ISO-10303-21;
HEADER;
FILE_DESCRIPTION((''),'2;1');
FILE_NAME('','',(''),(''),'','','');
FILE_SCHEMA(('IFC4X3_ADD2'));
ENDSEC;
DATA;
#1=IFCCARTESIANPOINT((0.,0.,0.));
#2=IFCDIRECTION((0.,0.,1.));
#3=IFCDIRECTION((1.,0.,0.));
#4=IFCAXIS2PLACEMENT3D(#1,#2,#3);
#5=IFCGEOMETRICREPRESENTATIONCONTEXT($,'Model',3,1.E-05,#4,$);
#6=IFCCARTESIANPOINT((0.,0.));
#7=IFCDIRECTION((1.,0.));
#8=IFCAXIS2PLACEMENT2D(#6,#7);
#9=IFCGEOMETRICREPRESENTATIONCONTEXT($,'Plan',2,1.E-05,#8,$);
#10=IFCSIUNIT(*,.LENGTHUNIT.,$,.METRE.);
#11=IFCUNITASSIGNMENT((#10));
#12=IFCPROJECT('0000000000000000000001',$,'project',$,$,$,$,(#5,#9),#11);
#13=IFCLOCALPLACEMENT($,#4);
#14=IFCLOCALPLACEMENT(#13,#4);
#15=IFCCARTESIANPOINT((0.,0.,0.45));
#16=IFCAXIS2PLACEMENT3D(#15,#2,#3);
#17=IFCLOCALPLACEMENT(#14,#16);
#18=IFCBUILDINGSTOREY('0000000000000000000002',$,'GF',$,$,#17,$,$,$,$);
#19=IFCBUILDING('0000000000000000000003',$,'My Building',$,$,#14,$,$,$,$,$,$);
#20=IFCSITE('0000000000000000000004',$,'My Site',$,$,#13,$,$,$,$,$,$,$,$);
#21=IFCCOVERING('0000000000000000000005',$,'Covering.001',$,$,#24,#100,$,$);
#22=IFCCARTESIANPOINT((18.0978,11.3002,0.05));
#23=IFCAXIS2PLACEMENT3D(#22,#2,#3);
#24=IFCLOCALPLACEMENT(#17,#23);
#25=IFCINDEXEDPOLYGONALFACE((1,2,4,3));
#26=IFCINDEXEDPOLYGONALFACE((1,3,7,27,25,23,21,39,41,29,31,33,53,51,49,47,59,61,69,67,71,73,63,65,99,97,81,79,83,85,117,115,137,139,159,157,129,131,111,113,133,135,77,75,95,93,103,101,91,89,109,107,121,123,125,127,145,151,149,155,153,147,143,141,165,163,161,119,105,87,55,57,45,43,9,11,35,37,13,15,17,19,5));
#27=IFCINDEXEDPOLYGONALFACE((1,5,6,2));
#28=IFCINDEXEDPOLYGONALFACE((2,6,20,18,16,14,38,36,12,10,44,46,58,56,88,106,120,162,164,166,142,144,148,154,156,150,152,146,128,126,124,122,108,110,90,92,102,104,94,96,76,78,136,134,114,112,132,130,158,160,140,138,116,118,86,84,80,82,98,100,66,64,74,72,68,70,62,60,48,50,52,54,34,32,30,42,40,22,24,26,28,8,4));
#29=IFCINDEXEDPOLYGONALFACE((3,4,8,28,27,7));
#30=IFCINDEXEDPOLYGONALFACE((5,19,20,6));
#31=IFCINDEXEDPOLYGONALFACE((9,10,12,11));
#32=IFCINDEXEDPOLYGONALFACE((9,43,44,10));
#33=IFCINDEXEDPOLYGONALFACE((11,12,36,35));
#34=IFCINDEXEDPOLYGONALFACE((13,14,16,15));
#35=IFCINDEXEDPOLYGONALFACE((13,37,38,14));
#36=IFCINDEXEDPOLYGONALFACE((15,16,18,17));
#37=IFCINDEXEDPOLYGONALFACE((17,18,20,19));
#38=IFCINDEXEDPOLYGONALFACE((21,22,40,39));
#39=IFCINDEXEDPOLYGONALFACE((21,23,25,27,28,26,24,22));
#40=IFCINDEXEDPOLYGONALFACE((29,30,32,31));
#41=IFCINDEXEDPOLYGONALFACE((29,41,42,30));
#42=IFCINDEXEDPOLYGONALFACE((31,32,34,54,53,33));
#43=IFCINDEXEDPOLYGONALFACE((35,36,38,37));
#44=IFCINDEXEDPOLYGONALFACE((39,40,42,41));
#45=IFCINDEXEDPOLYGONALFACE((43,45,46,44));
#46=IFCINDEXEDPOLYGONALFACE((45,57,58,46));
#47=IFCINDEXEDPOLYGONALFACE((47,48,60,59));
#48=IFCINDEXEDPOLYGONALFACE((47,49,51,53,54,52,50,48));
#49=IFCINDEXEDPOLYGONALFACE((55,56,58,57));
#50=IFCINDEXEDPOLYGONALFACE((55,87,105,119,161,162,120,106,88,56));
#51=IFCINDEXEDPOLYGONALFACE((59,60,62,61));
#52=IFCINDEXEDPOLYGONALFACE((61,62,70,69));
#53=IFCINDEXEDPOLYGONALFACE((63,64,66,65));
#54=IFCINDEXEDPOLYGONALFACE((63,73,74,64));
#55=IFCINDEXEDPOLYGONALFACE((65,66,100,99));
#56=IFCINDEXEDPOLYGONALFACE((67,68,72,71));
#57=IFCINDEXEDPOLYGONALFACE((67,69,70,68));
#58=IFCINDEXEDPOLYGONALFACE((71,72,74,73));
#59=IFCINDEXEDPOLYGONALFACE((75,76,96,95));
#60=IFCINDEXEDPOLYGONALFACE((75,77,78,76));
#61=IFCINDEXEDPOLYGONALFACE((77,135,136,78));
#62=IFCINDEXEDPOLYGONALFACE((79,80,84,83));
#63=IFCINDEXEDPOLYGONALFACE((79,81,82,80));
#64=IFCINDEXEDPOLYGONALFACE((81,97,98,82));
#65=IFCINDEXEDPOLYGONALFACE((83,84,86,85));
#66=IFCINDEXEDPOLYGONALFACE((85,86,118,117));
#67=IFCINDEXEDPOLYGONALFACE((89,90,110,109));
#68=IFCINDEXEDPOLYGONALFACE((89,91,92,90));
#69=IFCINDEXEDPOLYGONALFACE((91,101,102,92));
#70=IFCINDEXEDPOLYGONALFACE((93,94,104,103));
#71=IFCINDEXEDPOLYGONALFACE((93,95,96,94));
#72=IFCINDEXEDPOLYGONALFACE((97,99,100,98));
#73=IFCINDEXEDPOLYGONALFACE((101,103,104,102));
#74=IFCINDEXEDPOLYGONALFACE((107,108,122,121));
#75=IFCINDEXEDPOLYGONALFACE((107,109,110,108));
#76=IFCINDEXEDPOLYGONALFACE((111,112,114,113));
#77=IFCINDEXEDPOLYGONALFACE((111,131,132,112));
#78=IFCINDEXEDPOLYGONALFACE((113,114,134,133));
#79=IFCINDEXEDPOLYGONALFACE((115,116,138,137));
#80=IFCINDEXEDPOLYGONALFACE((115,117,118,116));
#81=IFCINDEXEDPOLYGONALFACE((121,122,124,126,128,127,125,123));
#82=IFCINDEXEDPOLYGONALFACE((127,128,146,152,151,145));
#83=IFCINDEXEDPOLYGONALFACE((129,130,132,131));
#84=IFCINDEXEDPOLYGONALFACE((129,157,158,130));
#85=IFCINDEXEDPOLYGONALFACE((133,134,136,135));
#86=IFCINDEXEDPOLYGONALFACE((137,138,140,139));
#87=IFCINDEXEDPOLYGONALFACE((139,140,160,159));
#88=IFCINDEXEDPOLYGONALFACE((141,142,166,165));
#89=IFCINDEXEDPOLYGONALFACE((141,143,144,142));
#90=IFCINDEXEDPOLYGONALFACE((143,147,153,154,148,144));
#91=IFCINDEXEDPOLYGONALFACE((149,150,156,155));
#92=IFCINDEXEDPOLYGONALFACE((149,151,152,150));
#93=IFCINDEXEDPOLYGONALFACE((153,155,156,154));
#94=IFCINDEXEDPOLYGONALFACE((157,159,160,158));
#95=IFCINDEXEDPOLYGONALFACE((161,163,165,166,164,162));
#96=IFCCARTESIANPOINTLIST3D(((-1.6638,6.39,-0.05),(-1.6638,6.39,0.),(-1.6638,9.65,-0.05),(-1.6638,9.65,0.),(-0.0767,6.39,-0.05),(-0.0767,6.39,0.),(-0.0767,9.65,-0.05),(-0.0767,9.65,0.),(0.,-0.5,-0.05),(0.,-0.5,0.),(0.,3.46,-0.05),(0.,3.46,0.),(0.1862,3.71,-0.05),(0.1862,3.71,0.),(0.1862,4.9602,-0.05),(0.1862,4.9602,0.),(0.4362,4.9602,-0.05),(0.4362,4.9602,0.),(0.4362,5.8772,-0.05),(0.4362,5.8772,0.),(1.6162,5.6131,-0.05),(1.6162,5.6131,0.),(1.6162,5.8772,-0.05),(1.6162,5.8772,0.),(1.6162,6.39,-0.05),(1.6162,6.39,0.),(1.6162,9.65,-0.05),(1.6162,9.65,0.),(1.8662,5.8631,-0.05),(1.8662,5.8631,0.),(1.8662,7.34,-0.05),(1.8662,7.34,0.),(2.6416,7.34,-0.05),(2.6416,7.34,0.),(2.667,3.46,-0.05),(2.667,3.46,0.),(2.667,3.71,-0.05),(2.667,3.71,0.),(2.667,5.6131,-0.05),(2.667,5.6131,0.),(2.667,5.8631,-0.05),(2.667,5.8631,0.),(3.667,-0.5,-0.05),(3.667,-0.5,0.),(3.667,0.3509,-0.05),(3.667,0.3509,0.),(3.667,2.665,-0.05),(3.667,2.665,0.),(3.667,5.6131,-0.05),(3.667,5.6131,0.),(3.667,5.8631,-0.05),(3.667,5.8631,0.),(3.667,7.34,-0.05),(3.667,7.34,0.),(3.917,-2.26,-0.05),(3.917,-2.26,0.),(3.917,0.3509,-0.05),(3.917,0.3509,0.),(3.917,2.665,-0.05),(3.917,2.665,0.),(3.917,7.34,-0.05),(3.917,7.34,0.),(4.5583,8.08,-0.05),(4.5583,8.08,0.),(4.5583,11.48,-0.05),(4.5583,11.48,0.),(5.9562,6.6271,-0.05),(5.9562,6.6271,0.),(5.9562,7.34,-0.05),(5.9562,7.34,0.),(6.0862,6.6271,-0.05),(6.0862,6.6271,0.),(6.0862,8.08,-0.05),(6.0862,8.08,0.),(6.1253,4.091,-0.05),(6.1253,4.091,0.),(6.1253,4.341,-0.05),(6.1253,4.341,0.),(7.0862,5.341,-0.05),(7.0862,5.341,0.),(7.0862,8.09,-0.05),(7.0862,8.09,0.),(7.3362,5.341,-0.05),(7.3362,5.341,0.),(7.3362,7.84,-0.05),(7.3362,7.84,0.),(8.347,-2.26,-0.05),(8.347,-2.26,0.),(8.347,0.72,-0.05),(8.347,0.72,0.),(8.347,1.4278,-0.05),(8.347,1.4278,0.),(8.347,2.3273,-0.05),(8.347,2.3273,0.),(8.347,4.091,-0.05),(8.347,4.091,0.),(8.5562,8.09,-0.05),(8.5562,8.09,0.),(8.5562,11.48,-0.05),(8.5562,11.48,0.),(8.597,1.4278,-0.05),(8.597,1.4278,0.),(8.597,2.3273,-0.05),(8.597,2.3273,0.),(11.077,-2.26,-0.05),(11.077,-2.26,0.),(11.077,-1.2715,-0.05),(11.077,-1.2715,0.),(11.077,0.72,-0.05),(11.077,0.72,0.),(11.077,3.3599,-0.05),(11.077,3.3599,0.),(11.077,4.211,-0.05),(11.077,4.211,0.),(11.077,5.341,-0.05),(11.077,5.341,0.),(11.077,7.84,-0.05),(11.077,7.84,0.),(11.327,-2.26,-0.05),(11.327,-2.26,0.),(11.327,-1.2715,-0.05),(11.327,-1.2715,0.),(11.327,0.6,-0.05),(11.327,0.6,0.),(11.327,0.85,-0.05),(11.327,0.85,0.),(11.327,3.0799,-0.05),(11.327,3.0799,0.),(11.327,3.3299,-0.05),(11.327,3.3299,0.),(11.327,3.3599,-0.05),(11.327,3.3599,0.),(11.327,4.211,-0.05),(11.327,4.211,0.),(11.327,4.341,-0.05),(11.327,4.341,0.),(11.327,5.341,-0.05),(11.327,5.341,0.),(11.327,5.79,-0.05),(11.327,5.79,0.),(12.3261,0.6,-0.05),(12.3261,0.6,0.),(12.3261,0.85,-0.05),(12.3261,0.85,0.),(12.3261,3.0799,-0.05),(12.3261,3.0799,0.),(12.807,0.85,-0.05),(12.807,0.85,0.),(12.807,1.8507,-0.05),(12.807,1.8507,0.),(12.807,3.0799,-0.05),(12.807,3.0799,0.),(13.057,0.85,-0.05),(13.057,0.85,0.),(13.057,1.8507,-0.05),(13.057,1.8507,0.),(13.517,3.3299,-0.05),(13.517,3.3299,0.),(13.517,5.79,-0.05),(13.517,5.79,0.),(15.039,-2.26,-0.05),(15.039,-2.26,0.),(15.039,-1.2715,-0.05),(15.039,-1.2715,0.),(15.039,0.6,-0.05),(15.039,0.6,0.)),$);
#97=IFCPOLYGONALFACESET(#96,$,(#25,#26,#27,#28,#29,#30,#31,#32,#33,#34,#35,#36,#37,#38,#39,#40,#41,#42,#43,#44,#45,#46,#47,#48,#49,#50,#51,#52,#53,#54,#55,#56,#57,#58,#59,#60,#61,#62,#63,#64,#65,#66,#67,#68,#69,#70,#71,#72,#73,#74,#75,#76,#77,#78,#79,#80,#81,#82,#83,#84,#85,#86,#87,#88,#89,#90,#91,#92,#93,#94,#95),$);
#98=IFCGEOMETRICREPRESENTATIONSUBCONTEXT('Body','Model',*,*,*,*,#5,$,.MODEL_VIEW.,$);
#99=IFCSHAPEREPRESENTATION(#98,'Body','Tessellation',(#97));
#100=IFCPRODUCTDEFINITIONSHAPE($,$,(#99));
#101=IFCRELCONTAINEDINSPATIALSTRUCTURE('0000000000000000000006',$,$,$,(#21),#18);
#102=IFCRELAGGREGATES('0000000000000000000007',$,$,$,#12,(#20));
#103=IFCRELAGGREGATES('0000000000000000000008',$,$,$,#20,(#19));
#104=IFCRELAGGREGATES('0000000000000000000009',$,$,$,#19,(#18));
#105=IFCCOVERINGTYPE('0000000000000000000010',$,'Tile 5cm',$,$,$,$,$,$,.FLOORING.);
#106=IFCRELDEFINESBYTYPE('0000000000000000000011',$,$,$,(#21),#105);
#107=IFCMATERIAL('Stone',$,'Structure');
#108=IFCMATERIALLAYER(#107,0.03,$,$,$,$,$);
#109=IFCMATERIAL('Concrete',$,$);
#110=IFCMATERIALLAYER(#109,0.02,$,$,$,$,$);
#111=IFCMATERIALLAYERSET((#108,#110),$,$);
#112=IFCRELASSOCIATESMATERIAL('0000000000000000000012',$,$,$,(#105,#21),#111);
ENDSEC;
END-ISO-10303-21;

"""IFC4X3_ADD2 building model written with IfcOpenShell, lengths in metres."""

from ifc_helpers import new_model, si_unit, frame, origin_with_axes, origin_2d_with_axis, place, context, subcontext, project, spatial, indexed_curve, outline, extrude, material, layer, layer_set, layer_usage, type_object, element, save


model = new_model("IFC4X3_ADD2")

# Units and contexts
model_context = context("Model", 3, precision=1e-05, world=origin_with_axes())
plan_context = context("Plan", 2, precision=1e-05, world=origin_2d_with_axis())
body_context_1 = subcontext(model_context, "Body", "Model", "MODEL_VIEW")
ifc_project = project(units=[si_unit("LENGTHUNIT", "METRE")], contexts=[model_context, plan_context])

# Site, building, storey
site_placement = place(None, origin_with_axes())
site = spatial("IfcSite", under=ifc_project, at=site_placement, Name="My Site")
building_placement = place(site_placement, origin_with_axes())
building = spatial("IfcBuilding", under=site, at=building_placement, Name="My Building")
storey_placement = place(building_placement, frame((0.0, 0.0, 0.45), z_axis=(0.0, 0.0, 1.0), x_axis=(1.0, 0.0, 0.0)))
storey = spatial("IfcBuildingStorey", under=building, at=storey_placement, Name="GF")

# Covering
ifc_material_1 = material(Name="Stone", Category="Structure")
ifc_layer_1 = layer(ifc_material_1, 0.03)
ifc_material_2 = material(Name="Concrete")
ifc_layer_2 = layer(ifc_material_2, 0.02)
ifc_layer_set = layer_set([ifc_layer_1, ifc_layer_2])
ifc_layer_usage = layer_usage(ifc_layer_set, "AXIS3", "POSITIVE", -0.05)
covering_type = type_object("IfcCoveringType", Name="Tile 5cm", PredefinedType="FLOORING", material=ifc_layer_set)
covering_placement = place(storey_placement, frame((18.0978, 11.3002, 0.05), z_axis=(0.0, 0.0, 1.0), x_axis=(1.0, 0.0, 0.0)))
element("IfcCovering", 1, at=covering_placement, inside=storey, type_object=covering_type, material=ifc_layer_usage, Name="Covering.001", context=body_context_1, shape_type="SweptSolid", body=[
    extrude(outline(indexed_curve([(2.667, 3.46), (2.667, 3.71), (0.1862, 3.71), (0.1862, 4.9602), (0.4362, 4.9602), (0.4362, 5.8772), (-0.0767, 6.39), (-1.6638, 6.39), (-1.6638, 9.65), (-0.0767, 9.65), (1.6162, 9.65), (1.6162, 6.39), (1.6162, 5.8772), (1.6162, 5.6131), (2.667, 5.6131), (2.667, 5.8631), (1.8662, 5.8631), (1.8662, 7.34), (2.6416, 7.34), (3.667, 7.34), (3.667, 5.8631), (3.667, 5.6131), (3.667, 2.665), (3.917, 2.665), (3.917, 7.34), (5.9562, 7.34), (5.9562, 6.6271), (6.0862, 6.6271), (6.0862, 8.08), (4.5583, 8.08), (4.5583, 11.48), (8.5562, 11.48), (8.5562, 8.09), (7.0862, 8.09), (7.0862, 5.341), (7.3362, 5.341), (7.3362, 7.84), (11.077, 7.84), (11.077, 5.341), (11.327, 5.341), (11.327, 5.79), (13.517, 5.79), (13.517, 3.3299), (11.327, 3.3299), (11.327, 3.3599), (11.077, 3.3599), (11.077, 4.211), (11.327, 4.211), (11.327, 4.341), (6.1253, 4.341), (6.1253, 4.091), (8.347, 4.091), (8.347, 2.3273), (8.597, 2.3273), (8.597, 1.4278), (8.347, 1.4278), (8.347, 0.72), (11.077, 0.72), (11.077, -1.2715), (11.327, -1.2715), (11.327, 0.6), (11.327, 0.85), (11.327, 3.0799), (12.3261, 3.0799), (12.807, 3.0799), (12.807, 1.8507), (13.057, 1.8507), (13.057, 0.85), (12.807, 0.85), (12.3261, 0.85), (12.3261, 0.6), (15.039, 0.6), (15.039, -1.2715), (15.039, -2.26), (11.327, -2.26), (11.077, -2.26), (8.347, -2.26), (3.917, -2.26), (3.917, 0.3509), (3.667, 0.3509), (3.667, -0.5), (0.0, -0.5), (0.0, 3.46), (2.667, 3.46)])), frame((0.0, 0.0, -0.05), z_axis=(0.0, 0.0, 1.0), x_axis=(1.0, 0.0, 0.0)), (0.0, 0.0, 1.0), 0.05),
])

save(model, "model.ifc")
